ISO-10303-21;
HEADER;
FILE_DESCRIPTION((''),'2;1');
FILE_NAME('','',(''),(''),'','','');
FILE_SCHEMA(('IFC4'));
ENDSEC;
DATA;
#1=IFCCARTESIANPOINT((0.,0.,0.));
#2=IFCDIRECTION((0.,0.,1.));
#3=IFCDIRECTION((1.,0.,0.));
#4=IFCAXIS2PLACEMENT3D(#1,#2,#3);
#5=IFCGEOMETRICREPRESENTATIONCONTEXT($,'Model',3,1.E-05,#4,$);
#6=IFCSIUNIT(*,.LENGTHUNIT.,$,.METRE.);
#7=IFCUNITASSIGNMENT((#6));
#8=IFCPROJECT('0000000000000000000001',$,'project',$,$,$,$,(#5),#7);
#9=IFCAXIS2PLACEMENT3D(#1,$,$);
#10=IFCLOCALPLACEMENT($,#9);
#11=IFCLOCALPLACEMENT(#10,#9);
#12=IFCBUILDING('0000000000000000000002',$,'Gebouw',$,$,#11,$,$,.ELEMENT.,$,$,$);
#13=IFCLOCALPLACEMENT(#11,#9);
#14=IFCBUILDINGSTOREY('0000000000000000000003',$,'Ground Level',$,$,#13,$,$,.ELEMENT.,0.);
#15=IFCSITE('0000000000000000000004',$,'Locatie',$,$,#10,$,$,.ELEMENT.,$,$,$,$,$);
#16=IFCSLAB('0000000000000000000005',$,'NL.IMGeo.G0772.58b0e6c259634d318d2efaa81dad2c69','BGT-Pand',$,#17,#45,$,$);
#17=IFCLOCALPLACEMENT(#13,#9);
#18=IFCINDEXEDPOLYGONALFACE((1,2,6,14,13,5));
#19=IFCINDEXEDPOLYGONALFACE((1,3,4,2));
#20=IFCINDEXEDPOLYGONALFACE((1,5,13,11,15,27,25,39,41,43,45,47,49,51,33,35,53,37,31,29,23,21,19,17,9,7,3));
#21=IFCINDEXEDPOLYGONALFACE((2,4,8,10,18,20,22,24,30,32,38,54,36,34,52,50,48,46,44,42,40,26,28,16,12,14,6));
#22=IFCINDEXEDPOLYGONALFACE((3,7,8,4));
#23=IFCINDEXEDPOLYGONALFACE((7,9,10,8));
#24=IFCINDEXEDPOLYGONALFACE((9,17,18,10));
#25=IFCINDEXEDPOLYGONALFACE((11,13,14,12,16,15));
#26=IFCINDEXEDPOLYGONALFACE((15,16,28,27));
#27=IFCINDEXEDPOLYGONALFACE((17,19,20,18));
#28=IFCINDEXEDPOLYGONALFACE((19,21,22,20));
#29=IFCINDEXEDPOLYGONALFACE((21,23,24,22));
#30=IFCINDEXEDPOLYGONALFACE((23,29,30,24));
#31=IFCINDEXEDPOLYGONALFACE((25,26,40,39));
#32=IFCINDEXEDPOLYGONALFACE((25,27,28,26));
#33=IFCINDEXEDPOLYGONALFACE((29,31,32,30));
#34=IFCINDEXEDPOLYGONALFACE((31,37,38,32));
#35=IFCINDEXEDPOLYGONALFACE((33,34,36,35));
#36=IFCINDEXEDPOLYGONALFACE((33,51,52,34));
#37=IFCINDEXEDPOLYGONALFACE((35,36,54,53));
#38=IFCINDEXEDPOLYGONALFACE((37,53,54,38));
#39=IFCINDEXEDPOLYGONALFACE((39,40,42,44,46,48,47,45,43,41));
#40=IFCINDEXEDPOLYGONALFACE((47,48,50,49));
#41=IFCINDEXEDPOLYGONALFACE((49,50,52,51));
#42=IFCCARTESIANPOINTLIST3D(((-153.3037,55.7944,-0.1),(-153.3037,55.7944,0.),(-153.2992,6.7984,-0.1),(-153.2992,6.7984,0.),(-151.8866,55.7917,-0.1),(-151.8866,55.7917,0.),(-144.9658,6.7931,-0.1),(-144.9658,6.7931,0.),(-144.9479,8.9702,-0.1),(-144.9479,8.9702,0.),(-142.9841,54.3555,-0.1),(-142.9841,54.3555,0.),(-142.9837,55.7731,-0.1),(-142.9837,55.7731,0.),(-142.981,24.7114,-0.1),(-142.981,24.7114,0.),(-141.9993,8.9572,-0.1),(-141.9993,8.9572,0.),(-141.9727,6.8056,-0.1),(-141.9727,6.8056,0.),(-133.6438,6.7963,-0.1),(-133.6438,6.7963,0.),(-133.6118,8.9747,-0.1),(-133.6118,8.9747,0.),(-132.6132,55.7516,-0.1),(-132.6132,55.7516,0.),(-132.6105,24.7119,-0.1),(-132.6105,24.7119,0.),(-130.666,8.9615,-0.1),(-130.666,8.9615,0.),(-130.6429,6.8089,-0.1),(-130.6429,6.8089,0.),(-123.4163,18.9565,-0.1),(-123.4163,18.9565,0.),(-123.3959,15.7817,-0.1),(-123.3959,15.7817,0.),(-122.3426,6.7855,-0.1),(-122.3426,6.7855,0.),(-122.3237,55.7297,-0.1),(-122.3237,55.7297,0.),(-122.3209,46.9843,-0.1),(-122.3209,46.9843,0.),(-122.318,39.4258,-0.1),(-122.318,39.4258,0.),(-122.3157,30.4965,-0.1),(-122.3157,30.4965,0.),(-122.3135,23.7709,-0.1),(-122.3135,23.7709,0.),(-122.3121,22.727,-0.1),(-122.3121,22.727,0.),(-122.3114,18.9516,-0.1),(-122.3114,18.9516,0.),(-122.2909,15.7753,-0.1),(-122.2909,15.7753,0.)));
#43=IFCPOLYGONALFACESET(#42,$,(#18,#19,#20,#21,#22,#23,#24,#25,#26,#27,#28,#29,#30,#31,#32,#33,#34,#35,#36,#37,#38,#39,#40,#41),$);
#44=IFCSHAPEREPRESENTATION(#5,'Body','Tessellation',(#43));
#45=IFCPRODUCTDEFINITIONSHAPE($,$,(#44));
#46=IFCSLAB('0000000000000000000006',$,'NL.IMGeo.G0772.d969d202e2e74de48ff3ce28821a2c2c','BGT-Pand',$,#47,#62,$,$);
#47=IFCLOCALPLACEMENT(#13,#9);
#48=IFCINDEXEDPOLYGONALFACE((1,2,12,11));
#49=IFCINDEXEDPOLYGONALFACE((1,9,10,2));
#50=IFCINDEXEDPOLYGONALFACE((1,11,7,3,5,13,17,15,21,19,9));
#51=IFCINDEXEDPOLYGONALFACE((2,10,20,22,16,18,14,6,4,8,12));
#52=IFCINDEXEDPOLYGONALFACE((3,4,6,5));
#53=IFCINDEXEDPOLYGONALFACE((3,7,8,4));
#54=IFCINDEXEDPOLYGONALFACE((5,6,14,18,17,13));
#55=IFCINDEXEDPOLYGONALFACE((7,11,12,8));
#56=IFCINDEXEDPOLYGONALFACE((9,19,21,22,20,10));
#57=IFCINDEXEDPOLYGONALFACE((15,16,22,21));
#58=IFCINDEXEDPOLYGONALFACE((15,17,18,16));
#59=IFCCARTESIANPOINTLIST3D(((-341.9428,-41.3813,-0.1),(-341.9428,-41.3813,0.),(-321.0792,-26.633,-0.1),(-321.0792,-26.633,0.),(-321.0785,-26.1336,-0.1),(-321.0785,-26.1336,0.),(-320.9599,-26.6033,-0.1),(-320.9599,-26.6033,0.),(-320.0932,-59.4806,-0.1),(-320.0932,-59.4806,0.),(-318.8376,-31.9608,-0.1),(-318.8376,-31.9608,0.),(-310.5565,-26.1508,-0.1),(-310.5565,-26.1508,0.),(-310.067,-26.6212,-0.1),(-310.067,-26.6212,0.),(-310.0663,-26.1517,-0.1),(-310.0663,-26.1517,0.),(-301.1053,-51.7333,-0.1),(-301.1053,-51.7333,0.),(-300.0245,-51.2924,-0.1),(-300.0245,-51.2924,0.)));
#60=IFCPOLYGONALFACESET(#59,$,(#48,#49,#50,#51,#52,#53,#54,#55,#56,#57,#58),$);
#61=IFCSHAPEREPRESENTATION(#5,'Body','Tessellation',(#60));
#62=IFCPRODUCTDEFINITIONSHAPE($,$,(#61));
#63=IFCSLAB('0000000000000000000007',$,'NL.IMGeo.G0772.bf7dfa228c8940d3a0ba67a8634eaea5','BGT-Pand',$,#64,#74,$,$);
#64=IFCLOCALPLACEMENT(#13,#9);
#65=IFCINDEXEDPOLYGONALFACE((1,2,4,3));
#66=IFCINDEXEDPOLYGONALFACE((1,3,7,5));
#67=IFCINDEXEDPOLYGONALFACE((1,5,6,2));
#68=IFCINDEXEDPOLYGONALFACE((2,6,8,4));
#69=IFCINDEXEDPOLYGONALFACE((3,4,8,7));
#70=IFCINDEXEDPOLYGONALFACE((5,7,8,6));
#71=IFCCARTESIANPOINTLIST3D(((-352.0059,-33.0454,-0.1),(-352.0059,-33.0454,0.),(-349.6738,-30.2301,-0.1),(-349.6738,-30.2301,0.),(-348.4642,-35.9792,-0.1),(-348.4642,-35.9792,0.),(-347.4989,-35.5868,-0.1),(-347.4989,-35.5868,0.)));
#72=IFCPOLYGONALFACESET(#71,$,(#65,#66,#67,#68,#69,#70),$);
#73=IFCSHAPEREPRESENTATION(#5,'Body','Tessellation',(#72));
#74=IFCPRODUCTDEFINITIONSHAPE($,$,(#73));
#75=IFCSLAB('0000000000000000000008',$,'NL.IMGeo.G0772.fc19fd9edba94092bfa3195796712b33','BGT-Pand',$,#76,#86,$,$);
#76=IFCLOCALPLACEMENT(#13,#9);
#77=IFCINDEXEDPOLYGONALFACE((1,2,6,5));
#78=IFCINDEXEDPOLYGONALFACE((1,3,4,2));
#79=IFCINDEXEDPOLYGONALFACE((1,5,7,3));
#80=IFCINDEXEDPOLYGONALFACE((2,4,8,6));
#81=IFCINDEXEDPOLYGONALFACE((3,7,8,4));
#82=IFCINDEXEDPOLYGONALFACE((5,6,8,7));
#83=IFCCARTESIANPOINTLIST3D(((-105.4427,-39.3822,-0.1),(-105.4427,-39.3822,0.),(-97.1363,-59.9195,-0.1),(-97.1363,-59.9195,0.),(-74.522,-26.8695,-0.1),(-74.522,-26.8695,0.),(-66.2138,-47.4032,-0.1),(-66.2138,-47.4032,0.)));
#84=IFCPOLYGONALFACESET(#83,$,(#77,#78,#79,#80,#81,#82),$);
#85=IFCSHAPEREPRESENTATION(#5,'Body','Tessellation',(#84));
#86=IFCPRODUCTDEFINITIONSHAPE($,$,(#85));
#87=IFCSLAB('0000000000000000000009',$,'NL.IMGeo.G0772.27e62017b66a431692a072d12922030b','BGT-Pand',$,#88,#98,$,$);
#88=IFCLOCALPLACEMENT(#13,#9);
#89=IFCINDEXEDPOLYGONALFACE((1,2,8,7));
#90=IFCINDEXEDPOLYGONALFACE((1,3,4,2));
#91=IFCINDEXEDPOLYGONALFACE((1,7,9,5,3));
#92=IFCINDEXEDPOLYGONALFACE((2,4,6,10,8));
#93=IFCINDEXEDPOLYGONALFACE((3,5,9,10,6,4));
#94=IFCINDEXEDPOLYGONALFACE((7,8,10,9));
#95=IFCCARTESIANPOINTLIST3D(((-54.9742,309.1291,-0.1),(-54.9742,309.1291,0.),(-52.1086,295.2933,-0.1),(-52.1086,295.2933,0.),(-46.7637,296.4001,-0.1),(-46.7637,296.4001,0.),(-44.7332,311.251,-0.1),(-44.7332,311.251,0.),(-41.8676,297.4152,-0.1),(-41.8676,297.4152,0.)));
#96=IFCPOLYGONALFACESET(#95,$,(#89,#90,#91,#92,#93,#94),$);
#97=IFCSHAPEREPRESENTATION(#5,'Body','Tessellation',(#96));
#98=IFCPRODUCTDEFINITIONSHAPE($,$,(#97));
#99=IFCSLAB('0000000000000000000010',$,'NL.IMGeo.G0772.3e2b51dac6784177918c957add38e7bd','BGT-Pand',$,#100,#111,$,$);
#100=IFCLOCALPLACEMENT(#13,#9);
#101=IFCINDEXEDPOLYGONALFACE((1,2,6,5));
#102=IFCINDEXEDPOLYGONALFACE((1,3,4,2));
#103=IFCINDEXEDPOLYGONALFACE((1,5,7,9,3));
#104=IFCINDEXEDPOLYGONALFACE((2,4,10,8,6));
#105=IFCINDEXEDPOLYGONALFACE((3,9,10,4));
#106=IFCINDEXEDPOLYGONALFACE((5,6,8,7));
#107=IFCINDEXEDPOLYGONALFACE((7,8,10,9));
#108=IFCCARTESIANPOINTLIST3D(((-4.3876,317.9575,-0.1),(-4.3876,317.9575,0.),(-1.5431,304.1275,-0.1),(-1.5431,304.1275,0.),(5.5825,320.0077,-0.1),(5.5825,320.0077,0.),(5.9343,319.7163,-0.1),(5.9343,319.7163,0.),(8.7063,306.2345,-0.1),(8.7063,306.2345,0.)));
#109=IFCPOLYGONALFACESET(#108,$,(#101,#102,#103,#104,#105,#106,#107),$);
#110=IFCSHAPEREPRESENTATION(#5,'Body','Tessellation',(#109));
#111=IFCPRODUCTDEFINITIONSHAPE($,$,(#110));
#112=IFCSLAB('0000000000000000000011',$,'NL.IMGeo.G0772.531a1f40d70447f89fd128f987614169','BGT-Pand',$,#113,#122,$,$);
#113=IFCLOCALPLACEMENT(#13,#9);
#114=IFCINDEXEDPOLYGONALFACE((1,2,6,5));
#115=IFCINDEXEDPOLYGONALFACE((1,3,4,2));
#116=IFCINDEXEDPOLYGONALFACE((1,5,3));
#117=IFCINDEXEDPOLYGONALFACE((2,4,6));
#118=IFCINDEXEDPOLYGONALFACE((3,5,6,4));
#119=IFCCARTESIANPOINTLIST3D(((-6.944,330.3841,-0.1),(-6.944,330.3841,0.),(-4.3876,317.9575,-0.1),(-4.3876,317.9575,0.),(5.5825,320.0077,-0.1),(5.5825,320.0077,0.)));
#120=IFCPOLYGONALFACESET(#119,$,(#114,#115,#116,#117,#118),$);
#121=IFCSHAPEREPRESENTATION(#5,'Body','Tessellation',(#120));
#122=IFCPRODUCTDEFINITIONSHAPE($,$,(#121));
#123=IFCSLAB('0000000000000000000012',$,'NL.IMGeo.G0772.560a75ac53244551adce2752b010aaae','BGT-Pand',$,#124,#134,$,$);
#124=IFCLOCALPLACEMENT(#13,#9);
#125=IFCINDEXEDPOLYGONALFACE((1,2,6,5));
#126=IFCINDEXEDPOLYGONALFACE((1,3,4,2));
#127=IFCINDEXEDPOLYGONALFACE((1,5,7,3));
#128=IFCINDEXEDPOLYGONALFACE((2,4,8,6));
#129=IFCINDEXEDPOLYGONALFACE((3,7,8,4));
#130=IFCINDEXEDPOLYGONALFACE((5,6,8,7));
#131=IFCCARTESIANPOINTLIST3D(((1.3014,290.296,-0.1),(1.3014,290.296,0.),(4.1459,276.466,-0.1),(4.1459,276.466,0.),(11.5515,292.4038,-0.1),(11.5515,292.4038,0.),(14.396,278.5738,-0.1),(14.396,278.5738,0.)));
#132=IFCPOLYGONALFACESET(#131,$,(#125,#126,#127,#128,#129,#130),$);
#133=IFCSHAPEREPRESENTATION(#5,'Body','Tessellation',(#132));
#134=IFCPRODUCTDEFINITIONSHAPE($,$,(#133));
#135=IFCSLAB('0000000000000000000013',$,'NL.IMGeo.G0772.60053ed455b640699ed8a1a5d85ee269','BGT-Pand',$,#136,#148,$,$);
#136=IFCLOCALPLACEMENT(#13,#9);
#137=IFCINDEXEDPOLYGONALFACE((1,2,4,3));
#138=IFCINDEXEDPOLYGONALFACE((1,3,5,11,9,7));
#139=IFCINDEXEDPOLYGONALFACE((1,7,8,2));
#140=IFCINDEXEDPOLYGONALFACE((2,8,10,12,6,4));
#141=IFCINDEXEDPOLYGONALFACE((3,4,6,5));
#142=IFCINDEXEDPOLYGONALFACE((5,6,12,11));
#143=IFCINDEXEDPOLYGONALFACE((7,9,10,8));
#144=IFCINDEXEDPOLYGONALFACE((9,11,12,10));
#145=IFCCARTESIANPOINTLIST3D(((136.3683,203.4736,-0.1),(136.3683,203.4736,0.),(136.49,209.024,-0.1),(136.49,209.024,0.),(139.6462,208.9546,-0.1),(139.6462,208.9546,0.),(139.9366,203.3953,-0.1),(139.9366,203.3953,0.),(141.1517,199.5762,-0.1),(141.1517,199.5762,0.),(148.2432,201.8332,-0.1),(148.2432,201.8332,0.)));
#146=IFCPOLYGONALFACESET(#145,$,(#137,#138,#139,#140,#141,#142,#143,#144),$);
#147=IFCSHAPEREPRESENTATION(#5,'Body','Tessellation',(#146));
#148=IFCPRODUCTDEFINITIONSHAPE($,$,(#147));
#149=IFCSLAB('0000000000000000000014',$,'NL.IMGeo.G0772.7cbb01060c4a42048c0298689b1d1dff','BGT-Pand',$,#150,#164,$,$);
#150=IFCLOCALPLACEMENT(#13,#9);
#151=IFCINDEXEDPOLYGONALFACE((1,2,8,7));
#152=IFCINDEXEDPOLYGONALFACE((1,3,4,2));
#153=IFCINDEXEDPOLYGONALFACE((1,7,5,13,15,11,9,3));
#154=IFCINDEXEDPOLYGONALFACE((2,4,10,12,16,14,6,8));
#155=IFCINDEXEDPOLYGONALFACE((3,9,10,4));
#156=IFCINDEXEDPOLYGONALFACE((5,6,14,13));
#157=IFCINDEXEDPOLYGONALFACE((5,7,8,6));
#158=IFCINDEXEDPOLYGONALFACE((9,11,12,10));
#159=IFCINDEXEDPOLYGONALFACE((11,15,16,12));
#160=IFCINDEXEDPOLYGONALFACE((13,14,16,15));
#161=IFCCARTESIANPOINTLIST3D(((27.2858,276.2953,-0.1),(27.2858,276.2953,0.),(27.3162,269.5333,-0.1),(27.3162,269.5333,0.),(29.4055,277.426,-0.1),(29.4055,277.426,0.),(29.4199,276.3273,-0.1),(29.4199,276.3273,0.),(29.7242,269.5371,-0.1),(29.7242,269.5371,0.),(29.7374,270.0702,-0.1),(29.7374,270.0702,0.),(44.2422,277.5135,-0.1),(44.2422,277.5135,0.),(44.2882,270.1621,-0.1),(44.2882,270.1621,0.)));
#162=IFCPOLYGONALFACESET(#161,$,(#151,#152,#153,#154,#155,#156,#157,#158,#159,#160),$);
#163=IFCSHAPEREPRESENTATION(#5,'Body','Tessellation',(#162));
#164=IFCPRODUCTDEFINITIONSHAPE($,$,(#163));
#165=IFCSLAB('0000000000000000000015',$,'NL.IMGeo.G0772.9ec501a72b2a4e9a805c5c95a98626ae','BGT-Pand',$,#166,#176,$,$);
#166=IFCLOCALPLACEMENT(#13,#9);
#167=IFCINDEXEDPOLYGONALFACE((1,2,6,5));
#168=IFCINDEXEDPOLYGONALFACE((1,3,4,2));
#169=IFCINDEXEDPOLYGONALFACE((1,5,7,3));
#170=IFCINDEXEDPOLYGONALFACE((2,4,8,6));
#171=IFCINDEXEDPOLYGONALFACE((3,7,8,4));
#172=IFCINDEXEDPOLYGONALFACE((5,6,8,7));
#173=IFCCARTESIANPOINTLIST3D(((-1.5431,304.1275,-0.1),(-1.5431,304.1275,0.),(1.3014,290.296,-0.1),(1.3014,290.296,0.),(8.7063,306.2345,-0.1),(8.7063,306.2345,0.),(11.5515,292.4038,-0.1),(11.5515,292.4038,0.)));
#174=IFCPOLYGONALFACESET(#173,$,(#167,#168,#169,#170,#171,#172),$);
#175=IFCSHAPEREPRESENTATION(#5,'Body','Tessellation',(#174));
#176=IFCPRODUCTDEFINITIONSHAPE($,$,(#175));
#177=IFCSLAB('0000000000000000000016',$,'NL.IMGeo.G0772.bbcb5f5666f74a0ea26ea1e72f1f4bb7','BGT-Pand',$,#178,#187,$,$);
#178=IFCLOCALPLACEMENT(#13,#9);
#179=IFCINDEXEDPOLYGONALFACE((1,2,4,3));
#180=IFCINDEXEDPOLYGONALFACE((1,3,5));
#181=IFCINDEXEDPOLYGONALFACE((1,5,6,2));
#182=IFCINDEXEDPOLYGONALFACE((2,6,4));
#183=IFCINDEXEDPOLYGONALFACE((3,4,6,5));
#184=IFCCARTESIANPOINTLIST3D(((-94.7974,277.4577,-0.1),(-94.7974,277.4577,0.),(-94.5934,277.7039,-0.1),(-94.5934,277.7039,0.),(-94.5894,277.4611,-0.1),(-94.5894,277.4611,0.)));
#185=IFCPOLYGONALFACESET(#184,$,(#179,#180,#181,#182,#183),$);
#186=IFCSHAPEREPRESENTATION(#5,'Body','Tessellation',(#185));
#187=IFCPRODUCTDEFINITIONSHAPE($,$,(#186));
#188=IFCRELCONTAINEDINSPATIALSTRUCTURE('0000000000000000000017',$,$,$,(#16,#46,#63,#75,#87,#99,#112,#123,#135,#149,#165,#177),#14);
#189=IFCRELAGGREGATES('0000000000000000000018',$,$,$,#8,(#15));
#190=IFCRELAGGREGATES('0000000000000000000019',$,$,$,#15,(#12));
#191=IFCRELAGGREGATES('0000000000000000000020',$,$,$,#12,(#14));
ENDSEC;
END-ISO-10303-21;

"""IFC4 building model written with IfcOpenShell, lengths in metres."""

from ifc_helpers import new_model, si_unit, frame, origin, origin_with_axes, place, context, project, spatial, polyline, outline, extrude, element, save


model = new_model("IFC4")

# Units and contexts
model_context = context("Model", 3, precision=1e-05, world=origin_with_axes())
ifc_project = project(units=[si_unit("LENGTHUNIT", "METRE")], contexts=[model_context])

# Site, building, storey
site_placement = place(None, origin())
site = spatial("IfcSite", under=ifc_project, at=site_placement, Name="Locatie", CompositionType="ELEMENT")
building_placement = place(site_placement, origin())
building = spatial("IfcBuilding", under=site, at=building_placement, Name="Gebouw", CompositionType="ELEMENT")
storey_placement = place(building_placement, origin())
storey = spatial("IfcBuildingStorey", under=building, at=storey_placement, Name="Ground Level", CompositionType="ELEMENT", Elevation=0.0)

# Slabs
slab_1_placement = place(storey_placement, origin())
element("IfcSlab", 1, at=slab_1_placement, inside=storey, Name="NL.IMGeo.G0772.58b0e6c259634d318d2efaa81dad2c69", Description="BGT-Pand", context=model_context, shape_type="SweptSolid", body=[
    extrude(outline(polyline([(-122.3157, 30.4965), (-122.3135, 23.7709), (-122.3121, 22.727), (-122.3114, 18.9516), (-123.4163, 18.9565), (-123.3959, 15.7817), (-122.2909, 15.7753), (-122.3426, 6.7855), (-130.6429, 6.8089), (-130.666, 8.9615), (-133.6118, 8.9747), (-133.6438, 6.7963), (-141.9727, 6.8056), (-141.9993, 8.9572), (-144.9479, 8.9702), (-144.9658, 6.7931), (-153.2992, 6.7984), (-153.3037, 55.7944), (-151.8866, 55.7917), (-142.9837, 55.7731), (-142.9841, 54.3555), (-142.981, 24.7114), (-132.6105, 24.7119), (-132.6132, 55.7516), (-122.3237, 55.7297), (-122.3209, 46.9843), (-122.318, 39.4258), (-122.3157, 30.4965)])), frame((0.0, 0.0, -0.1), z_axis=(0.0, 0.0, 1.0), x_axis=(1.0, 0.0, 0.0)), (0.0, 0.0, 1.0), 0.1),
])
slab_2_placement = place(storey_placement, origin())
element("IfcSlab", 2, at=slab_2_placement, inside=storey, Name="NL.IMGeo.G0772.d969d202e2e74de48ff3ce28821a2c2c", Description="BGT-Pand", context=model_context, shape_type="SweptSolid", body=[
    extrude(outline(polyline([(-318.8376, -31.9608), (-320.9599, -26.6033), (-321.0792, -26.633), (-321.0785, -26.1336), (-310.5565, -26.1508), (-310.0663, -26.1517), (-310.067, -26.6212), (-300.0245, -51.2924), (-301.1053, -51.7333), (-320.0932, -59.4806), (-341.9428, -41.3813), (-318.8376, -31.9608)])), frame((0.0, 0.0, -0.1), z_axis=(0.0, 0.0, 1.0), x_axis=(1.0, 0.0, 0.0)), (0.0, 0.0, 1.0), 0.1),
])
slab_3_placement = place(storey_placement, origin())
element("IfcSlab", 3, at=slab_3_placement, inside=storey, Name="NL.IMGeo.G0772.bf7dfa228c8940d3a0ba67a8634eaea5", Description="BGT-Pand", context=model_context, shape_type="SweptSolid", body=[
    extrude(outline(polyline([(-347.4989, -35.5868), (-348.4642, -35.9792), (-352.0059, -33.0454), (-349.6738, -30.2301), (-347.4989, -35.5868)])), frame((0.0, 0.0, -0.1), z_axis=(0.0, 0.0, 1.0), x_axis=(1.0, 0.0, 0.0)), (0.0, 0.0, 1.0), 0.1),
])
slab_4_placement = place(storey_placement, origin())
element("IfcSlab", 4, at=slab_4_placement, inside=storey, Name="NL.IMGeo.G0772.fc19fd9edba94092bfa3195796712b33", Description="BGT-Pand", context=model_context, shape_type="SweptSolid", body=[
    extrude(outline(polyline([(-66.2138, -47.4032), (-97.1363, -59.9195), (-105.4427, -39.3822), (-74.522, -26.8695), (-66.2138, -47.4032)])), frame((0.0, 0.0, -0.1), z_axis=(0.0, 0.0, 1.0), x_axis=(1.0, 0.0, 0.0)), (0.0, 0.0, 1.0), 0.1),
])
slab_5_placement = place(storey_placement, origin())
element("IfcSlab", 5, at=slab_5_placement, inside=storey, Name="NL.IMGeo.G0772.27e62017b66a431692a072d12922030b", Description="BGT-Pand", context=model_context, shape_type="SweptSolid", body=[
    extrude(outline(polyline([(-44.7332, 311.251), (-41.8676, 297.4152), (-46.7637, 296.4001), (-52.1086, 295.2933), (-54.9742, 309.1291), (-44.7332, 311.251)])), frame((0.0, 0.0, -0.1), z_axis=(0.0, 0.0, 1.0), x_axis=(1.0, 0.0, 0.0)), (0.0, 0.0, 1.0), 0.1),
])
slab_6_placement = place(storey_placement, origin())
element("IfcSlab", 6, at=slab_6_placement, inside=storey, Name="NL.IMGeo.G0772.3e2b51dac6784177918c957add38e7bd", Description="BGT-Pand", context=model_context, shape_type="SweptSolid", body=[
    extrude(outline(polyline([(8.7063, 306.2345), (-1.5431, 304.1275), (-4.3876, 317.9575), (5.5825, 320.0077), (5.9343, 319.7163), (8.7063, 306.2345)])), frame((0.0, 0.0, -0.1), z_axis=(0.0, 0.0, 1.0), x_axis=(1.0, 0.0, 0.0)), (0.0, 0.0, 1.0), 0.1),
])
slab_7_placement = place(storey_placement, origin())
element("IfcSlab", 7, at=slab_7_placement, inside=storey, Name="NL.IMGeo.G0772.531a1f40d70447f89fd128f987614169", Description="BGT-Pand", context=model_context, shape_type="SweptSolid", body=[
    extrude(outline(polyline([(-4.3876, 317.9575), (-6.944, 330.3841), (5.5825, 320.0077), (-4.3876, 317.9575)])), frame((0.0, 0.0, -0.1), z_axis=(0.0, 0.0, 1.0), x_axis=(1.0, 0.0, 0.0)), (0.0, 0.0, 1.0), 0.1),
])
slab_8_placement = place(storey_placement, origin())
element("IfcSlab", 8, at=slab_8_placement, inside=storey, Name="NL.IMGeo.G0772.560a75ac53244551adce2752b010aaae", Description="BGT-Pand", context=model_context, shape_type="SweptSolid", body=[
    extrude(outline(polyline([(11.5515, 292.4038), (14.396, 278.5738), (4.1459, 276.466), (1.3014, 290.296), (11.5515, 292.4038)])), frame((0.0, 0.0, -0.1), z_axis=(0.0, 0.0, 1.0), x_axis=(1.0, 0.0, 0.0)), (0.0, 0.0, 1.0), 0.1),
])
slab_9_placement = place(storey_placement, origin())
element("IfcSlab", 9, at=slab_9_placement, inside=storey, Name="NL.IMGeo.G0772.60053ed455b640699ed8a1a5d85ee269", Description="BGT-Pand", context=model_context, shape_type="SweptSolid", body=[
    extrude(outline(polyline([(141.1517, 199.5762), (139.9366, 203.3953), (136.3683, 203.4736), (136.49, 209.024), (139.6462, 208.9546), (148.2432, 201.8332), (141.1517, 199.5762)])), frame((0.0, 0.0, -0.1), z_axis=(0.0, 0.0, 1.0), x_axis=(1.0, 0.0, 0.0)), (0.0, 0.0, 1.0), 0.1),
])
slab_10_placement = place(storey_placement, origin())
element("IfcSlab", 10, at=slab_10_placement, inside=storey, Name="NL.IMGeo.G0772.7cbb01060c4a42048c0298689b1d1dff", Description="BGT-Pand", context=model_context, shape_type="SweptSolid", body=[
    extrude(outline(polyline([(29.7374, 270.0702), (29.7242, 269.5371), (27.3162, 269.5333), (27.2858, 276.2953), (29.4199, 276.3273), (29.4055, 277.426), (44.2422, 277.5135), (44.2882, 270.1621), (29.7374, 270.0702)])), frame((0.0, 0.0, -0.1), z_axis=(0.0, 0.0, 1.0), x_axis=(1.0, 0.0, 0.0)), (0.0, 0.0, 1.0), 0.1),
])
slab_11_placement = place(storey_placement, origin())
element("IfcSlab", 11, at=slab_11_placement, inside=storey, Name="NL.IMGeo.G0772.9ec501a72b2a4e9a805c5c95a98626ae", Description="BGT-Pand", context=model_context, shape_type="SweptSolid", body=[
    extrude(outline(polyline([(11.5515, 292.4038), (1.3014, 290.296), (-1.5431, 304.1275), (8.7063, 306.2345), (11.5515, 292.4038)])), frame((0.0, 0.0, -0.1), z_axis=(0.0, 0.0, 1.0), x_axis=(1.0, 0.0, 0.0)), (0.0, 0.0, 1.0), 0.1),
])
slab_12_placement = place(storey_placement, origin())
element("IfcSlab", 12, at=slab_12_placement, inside=storey, Name="NL.IMGeo.G0772.bbcb5f5666f74a0ea26ea1e72f1f4bb7", Description="BGT-Pand", context=model_context, shape_type="SweptSolid", body=[
    extrude(outline(polyline([(-94.5894, 277.4611), (-94.7974, 277.4577), (-94.5934, 277.7039), (-94.5894, 277.4611)])), frame((0.0, 0.0, -0.1), z_axis=(0.0, 0.0, 1.0), x_axis=(1.0, 0.0, 0.0)), (0.0, 0.0, 1.0), 0.1),
])

save(model, "model.ifc")
